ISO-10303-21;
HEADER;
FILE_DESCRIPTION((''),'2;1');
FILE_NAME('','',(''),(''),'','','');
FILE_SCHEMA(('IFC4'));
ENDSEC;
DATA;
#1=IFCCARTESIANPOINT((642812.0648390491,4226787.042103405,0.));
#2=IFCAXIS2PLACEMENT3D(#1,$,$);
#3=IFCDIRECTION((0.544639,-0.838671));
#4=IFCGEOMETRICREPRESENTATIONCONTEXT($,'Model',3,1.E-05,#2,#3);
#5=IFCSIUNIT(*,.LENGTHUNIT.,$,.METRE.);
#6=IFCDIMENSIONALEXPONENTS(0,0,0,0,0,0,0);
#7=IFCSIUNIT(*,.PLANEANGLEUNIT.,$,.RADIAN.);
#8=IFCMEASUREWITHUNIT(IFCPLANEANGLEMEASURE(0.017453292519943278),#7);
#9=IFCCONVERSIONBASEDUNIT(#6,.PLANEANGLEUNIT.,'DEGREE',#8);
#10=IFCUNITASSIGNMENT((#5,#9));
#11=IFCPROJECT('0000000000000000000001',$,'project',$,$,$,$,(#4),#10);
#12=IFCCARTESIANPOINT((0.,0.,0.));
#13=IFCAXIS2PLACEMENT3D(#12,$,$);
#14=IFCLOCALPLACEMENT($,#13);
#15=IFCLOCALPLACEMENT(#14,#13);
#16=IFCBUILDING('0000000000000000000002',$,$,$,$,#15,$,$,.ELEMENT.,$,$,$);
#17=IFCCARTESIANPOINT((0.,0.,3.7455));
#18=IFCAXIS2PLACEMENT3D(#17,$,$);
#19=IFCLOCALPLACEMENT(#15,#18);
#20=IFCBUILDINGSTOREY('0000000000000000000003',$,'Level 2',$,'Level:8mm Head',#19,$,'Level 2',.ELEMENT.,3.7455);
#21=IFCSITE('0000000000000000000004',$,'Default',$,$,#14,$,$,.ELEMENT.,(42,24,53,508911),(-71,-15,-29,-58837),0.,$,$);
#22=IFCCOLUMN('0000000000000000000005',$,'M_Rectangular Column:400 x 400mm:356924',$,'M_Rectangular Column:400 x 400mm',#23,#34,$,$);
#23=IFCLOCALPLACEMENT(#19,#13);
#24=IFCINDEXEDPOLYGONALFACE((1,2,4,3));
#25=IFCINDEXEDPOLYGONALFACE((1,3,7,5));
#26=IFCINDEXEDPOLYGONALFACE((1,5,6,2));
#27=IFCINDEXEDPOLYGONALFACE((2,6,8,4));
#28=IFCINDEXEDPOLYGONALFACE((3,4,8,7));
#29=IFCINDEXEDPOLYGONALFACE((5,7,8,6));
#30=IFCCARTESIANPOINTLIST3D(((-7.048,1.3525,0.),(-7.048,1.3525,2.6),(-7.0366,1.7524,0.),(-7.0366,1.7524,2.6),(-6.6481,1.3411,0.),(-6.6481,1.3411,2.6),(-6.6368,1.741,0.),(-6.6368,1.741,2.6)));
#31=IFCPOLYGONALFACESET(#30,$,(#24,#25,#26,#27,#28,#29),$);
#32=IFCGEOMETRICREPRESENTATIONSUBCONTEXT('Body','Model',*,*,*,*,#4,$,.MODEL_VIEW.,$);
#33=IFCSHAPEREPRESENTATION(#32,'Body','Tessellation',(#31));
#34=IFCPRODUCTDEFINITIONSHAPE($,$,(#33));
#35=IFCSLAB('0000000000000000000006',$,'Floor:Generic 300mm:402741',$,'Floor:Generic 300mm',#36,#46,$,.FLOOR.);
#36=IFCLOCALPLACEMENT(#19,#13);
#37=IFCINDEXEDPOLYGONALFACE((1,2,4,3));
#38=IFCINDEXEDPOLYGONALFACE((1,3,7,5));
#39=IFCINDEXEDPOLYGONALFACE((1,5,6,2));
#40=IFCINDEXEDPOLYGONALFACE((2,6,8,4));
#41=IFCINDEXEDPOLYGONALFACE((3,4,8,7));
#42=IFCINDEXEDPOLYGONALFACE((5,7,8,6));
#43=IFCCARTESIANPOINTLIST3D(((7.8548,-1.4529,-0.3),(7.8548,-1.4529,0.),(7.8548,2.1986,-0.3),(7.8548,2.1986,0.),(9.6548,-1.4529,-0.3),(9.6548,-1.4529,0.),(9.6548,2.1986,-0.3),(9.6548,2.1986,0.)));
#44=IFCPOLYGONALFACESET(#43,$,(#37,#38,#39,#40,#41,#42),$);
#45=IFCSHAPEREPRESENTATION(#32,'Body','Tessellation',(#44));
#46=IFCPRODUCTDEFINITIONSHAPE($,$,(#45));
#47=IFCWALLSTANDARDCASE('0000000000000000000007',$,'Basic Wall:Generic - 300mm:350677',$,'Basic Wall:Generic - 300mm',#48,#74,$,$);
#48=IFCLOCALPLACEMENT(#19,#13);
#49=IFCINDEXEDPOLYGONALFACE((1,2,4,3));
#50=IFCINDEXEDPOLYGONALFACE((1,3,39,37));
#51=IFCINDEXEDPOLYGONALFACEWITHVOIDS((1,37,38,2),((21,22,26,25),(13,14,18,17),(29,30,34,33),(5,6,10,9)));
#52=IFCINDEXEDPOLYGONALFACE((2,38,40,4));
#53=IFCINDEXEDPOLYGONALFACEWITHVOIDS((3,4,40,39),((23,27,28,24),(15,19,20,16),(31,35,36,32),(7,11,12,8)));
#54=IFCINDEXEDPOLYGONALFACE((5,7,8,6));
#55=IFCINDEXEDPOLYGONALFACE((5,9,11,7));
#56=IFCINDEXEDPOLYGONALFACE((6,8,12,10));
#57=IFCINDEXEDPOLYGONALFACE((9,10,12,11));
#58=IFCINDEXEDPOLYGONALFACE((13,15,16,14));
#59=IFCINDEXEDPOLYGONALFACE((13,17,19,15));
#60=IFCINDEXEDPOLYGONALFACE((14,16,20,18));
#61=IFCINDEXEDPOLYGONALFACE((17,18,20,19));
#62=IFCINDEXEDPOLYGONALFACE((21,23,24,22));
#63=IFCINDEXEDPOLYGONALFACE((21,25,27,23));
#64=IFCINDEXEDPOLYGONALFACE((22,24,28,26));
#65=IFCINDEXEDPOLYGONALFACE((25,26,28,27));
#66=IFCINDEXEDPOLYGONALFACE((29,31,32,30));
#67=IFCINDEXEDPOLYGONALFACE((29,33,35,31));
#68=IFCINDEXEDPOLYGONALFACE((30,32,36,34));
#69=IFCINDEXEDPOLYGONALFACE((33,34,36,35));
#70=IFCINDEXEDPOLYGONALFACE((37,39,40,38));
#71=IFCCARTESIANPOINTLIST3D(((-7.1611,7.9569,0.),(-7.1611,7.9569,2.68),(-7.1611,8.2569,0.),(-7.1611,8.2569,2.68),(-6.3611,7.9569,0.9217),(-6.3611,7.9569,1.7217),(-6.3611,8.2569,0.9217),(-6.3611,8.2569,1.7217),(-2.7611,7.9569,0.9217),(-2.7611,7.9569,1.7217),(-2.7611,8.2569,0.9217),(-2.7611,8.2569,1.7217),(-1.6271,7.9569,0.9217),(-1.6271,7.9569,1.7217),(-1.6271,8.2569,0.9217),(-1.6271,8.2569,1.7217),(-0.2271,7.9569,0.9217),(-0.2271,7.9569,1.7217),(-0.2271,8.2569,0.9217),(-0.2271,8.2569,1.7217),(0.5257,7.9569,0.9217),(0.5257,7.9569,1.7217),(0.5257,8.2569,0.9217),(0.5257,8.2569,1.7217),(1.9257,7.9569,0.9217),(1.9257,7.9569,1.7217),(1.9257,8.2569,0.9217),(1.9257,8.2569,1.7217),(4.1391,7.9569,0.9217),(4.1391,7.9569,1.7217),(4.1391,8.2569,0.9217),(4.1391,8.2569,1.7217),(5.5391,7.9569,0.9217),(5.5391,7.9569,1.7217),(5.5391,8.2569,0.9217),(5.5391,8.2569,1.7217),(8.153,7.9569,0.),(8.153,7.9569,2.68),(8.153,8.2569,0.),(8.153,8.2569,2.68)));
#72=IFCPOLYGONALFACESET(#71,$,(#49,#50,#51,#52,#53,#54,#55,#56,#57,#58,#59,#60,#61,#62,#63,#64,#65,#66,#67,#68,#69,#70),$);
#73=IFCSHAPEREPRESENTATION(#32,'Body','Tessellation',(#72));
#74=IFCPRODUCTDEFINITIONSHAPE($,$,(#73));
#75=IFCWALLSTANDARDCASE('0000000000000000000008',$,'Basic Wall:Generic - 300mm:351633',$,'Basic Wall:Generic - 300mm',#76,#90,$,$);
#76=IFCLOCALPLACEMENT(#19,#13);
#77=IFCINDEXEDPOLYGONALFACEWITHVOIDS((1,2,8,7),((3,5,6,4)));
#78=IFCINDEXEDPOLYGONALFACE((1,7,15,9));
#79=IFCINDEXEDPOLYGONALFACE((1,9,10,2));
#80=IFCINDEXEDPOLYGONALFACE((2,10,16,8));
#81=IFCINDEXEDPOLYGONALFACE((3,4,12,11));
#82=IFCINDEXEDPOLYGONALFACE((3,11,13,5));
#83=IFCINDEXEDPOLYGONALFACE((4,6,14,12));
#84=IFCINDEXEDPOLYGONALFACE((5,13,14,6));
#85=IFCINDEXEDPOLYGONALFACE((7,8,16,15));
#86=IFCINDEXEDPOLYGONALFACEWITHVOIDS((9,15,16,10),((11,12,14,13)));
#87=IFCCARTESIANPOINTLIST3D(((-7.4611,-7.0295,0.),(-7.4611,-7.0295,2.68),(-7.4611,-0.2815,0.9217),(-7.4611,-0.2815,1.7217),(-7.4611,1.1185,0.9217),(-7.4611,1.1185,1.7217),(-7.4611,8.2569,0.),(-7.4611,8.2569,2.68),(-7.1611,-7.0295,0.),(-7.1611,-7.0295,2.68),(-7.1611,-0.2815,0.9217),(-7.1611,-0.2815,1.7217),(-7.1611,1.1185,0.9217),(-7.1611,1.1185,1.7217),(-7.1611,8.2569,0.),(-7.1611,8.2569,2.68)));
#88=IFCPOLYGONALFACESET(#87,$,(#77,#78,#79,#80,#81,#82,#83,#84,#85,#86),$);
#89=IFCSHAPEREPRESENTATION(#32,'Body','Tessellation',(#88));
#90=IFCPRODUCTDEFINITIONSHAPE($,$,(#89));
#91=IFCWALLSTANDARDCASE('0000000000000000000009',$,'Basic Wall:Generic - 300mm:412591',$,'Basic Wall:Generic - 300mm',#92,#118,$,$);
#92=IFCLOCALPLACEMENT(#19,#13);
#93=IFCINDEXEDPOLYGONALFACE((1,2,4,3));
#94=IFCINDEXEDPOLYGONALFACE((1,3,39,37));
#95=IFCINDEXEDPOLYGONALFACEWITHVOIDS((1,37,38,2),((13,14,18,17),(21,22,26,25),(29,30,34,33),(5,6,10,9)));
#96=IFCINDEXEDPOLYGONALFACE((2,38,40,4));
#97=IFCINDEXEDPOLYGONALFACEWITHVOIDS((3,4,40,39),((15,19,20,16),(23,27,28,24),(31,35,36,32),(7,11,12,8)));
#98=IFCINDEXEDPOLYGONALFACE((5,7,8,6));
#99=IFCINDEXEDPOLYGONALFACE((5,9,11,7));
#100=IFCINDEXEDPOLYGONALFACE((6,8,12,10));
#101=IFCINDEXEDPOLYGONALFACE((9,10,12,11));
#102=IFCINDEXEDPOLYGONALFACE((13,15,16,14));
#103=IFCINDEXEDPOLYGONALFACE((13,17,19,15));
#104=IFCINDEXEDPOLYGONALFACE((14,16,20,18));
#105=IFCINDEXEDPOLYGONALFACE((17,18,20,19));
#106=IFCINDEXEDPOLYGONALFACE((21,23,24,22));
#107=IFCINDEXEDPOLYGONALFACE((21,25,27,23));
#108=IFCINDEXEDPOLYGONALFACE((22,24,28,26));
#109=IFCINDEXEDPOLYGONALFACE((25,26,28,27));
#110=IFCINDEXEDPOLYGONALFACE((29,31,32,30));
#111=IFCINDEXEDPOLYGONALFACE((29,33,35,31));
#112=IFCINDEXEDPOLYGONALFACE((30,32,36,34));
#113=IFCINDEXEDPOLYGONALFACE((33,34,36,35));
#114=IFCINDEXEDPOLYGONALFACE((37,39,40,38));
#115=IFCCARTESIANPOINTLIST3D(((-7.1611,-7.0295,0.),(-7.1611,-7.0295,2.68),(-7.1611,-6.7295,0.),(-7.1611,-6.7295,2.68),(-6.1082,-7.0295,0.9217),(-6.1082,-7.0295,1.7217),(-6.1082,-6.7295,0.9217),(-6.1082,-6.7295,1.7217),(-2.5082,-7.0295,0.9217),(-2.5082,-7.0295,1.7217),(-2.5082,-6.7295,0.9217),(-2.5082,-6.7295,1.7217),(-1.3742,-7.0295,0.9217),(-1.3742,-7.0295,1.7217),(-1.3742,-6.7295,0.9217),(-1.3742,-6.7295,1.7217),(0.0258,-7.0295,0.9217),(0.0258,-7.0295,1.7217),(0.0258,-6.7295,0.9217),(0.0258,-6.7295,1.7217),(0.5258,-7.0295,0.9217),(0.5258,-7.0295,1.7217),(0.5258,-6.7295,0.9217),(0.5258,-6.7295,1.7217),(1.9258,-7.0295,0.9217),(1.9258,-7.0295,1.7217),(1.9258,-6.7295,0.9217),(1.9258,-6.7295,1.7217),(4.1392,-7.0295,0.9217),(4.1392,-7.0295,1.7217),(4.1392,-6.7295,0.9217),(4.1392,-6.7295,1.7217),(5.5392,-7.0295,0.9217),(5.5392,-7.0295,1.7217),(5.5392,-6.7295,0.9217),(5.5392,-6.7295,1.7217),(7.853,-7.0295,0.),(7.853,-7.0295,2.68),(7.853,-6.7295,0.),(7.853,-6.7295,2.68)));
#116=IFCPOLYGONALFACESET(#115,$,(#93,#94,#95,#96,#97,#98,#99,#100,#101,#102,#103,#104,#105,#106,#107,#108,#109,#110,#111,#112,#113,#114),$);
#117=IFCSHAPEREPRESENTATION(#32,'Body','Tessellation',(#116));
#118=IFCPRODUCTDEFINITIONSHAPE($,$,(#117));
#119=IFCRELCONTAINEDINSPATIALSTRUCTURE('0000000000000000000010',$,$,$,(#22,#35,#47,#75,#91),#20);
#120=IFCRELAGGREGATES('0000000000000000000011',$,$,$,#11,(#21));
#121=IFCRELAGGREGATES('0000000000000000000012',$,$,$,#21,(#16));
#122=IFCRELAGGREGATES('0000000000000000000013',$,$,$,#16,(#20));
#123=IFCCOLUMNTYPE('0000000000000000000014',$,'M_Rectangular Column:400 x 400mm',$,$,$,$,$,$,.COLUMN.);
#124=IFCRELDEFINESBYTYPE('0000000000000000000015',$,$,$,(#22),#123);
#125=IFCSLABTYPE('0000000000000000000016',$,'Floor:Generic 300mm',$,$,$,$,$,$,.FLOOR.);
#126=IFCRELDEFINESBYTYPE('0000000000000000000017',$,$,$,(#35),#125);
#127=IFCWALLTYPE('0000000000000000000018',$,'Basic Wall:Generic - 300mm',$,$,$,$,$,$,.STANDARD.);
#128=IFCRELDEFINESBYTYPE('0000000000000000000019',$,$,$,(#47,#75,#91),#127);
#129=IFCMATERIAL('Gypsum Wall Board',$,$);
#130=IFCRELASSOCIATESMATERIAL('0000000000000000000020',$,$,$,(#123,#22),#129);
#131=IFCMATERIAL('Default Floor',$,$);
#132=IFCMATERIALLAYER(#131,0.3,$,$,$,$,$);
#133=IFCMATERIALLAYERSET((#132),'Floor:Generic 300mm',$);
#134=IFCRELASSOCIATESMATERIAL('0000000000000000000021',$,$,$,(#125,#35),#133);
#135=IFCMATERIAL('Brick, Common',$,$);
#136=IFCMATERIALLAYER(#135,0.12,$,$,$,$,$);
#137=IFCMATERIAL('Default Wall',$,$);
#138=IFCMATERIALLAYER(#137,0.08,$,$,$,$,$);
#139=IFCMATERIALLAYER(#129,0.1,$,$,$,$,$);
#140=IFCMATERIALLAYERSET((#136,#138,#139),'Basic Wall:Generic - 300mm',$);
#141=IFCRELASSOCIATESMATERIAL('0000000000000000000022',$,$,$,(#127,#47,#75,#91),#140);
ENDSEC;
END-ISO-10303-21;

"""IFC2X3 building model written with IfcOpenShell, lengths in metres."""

from ifc_helpers import new_model, entity, si_unit, converted_unit, direction, frame, frame_2d, origin, place, context, subcontext, project, spatial, rectangle, extrude, clip, halfspace, source, transform, mapped, material, layer, layer_set, layer_usage, type_object, type_shapes, element, save


model = new_model("IFC2X3")

# Units and contexts
model_context = context("Model", 3, precision=1e-05, world=frame((642812.0648390491, 4226787.042103405, 0.0)), true_north=direction((0.544639, -0.838671)))
body_context = subcontext(model_context, "Body", "Model", "MODEL_VIEW")
ifc_project = project(units=[si_unit("LENGTHUNIT", "METRE"), converted_unit("PLANEANGLEUNIT", "DEGREE", entity("IfcPlaneAngleMeasure", 0.017453292519943278), si_unit("PLANEANGLEUNIT", "RADIAN"), dimensions=[0, 0, 0, 0, 0, 0, 0])], contexts=[model_context])

# Site, building, storey
site_placement = place(None, origin())
site = spatial("IfcSite", under=ifc_project, at=site_placement, Name="Default", CompositionType="ELEMENT", RefLatitude=(42, 24, 53, 508911), RefLongitude=(-71, -15, -29, -58837), RefElevation=0.0)
building_placement = place(site_placement, origin())
building = spatial("IfcBuilding", under=site, at=building_placement, CompositionType="ELEMENT")
storey_placement = place(building_placement, frame((0.0, 0.0, 3.7455)))
storey = spatial("IfcBuildingStorey", under=building, at=storey_placement, Name="Level 2", ObjectType="Level:8mm Head", LongName="Level 2", CompositionType="ELEMENT", Elevation=3.7455)

# Column
ifc_material_1 = material(Name="Gypsum Wall Board")
column_type_1 = type_object("IfcColumnType", Name="M_Rectangular Column:400 x 400mm", PredefinedType="COLUMN", material=ifc_material_1)
shared_shape_1 = source(origin(), body_context, "Body", "SweptSolid", [
    extrude(rectangle(XDim=0.4, YDim=0.4, at=frame_2d((0.0, 0.0), x_axis=(1.0, 0.0))), frame((-6.8424, 1.5467, 3.7455), z_axis=(0.0, 0.0, 1.0), x_axis=(0.999595, -0.02845, 0.0)), (0.0, 0.0, 1.0), 2.6),
])
type_shapes(column_type_1, [shared_shape_1])
column_1_placement = place(storey_placement, frame((0.0, 0.0, -3.7455)))
element("IfcColumn", 1, at=column_1_placement, inside=storey, type_object=column_type_1, material=ifc_material_1, Name="M_Rectangular Column:400 x 400mm:356924", ObjectType="M_Rectangular Column:400 x 400mm", context=body_context, shape_type="MappedRepresentation", body=[
    mapped(shared_shape_1, transform((0.0, 0.0, 0.0), scale=1.0)),
])

# Slab
ifc_material_2 = material(Name="Default Floor")
ifc_layer_1 = layer(ifc_material_2, 0.3)
ifc_layer_set_1 = layer_set([ifc_layer_1], Name="Floor:Generic 300mm")
ifc_layer_usage_1 = layer_usage(ifc_layer_set_1, "AXIS3", "POSITIVE", 0.0)
slab_type_1 = type_object("IfcSlabType", Name="Floor:Generic 300mm", PredefinedType="FLOOR", material=ifc_layer_set_1)
slab_1_placement = place(storey_placement, origin())
element("IfcSlab", 2, at=slab_1_placement, inside=storey, type_object=slab_type_1, material=ifc_layer_usage_1, Name="Floor:Generic 300mm:402741", ObjectType="Floor:Generic 300mm", PredefinedType="FLOOR", context=body_context, shape_type="SweptSolid", body=[
    extrude(rectangle(XDim=3.6515, YDim=1.8, at=frame_2d((0.0, 0.0), x_axis=(1.0, 0.0))), frame((8.7548, 0.3729, 0.0), z_axis=(0.0, 0.0, -1.0), x_axis=(0.0, 1.0, 0.0)), (0.0, 0.0, 1.0), 0.3),
])

# Wall, openings
ifc_material_3 = material(Name="Brick, Common")
ifc_layer_2 = layer(ifc_material_3, 0.12)
ifc_material_4 = material(Name="Default Wall")
ifc_layer_3 = layer(ifc_material_4, 0.08)
ifc_layer_4 = layer(ifc_material_1, 0.1)
ifc_layer_set_2 = layer_set([ifc_layer_2, ifc_layer_3, ifc_layer_4], Name="Basic Wall:Generic - 300mm")
ifc_layer_usage_2 = layer_usage(ifc_layer_set_2, "AXIS2", "POSITIVE", -0.15)
wall_type = type_object("IfcWallType", Name="Basic Wall:Generic - 300mm", PredefinedType="STANDARD", material=ifc_layer_set_2)
wall_1_placement = place(storey_placement, frame((8.153, 8.1069, 0.0), z_axis=(0.0, 0.0, 1.0), x_axis=(-1.0, 0.0, 0.0)))
wall_1 = element("IfcWallStandardCase", 3, at=wall_1_placement, inside=storey, type_object=wall_type, material=ifc_layer_usage_2, Name="Basic Wall:Generic - 300mm:350677", ObjectType="Basic Wall:Generic - 300mm", context=body_context, shape_type="Clipping", body=[
    clip(extrude(rectangle(XDim=15.314, YDim=0.3, at=frame_2d((7.657, 0.0), x_axis=(-1.0, 0.0))), origin(), (0.0, 0.0, 1.0), 2.68), halfspace(frame((0.0, 0.0, -3.7455)), True)),
])
opening_1_placement = place(wall_1_placement, frame((14.514, 0.15, 0.9217)))
element("IfcOpeningElement", 4, at=opening_1_placement, cuts=wall_1, ObjectType="Opening", context=body_context, shape_type="SweptSolid", body=[
    extrude(rectangle(XDim=0.8, YDim=3.6, at=frame_2d((0.4, 1.8), x_axis=(-1.0, 0.0))), frame((0.0, 0.0, 0.0), z_axis=(0.0, -1.0, 0.0), x_axis=(0.0, 0.0, 1.0)), (0.0, 0.0, 1.0), 0.3),
])
opening_2_placement = place(wall_1_placement, frame((9.7801, 0.15, 0.9217)))
element("IfcOpeningElement", 5, at=opening_2_placement, cuts=wall_1, ObjectType="Opening", context=body_context, shape_type="SweptSolid", body=[
    extrude(rectangle(XDim=0.8, YDim=1.4, at=frame_2d((0.4, 0.7), x_axis=(-1.0, 0.0))), frame((0.0, 0.0, 0.0), z_axis=(0.0, -1.0, 0.0), x_axis=(0.0, 0.0, 1.0)), (0.0, 0.0, 1.0), 0.3),
])
opening_3_placement = place(wall_1_placement, frame((7.6272, 0.15, 0.9217)))
element("IfcOpeningElement", 6, at=opening_3_placement, cuts=wall_1, ObjectType="Opening", context=body_context, shape_type="SweptSolid", body=[
    extrude(rectangle(XDim=0.8, YDim=1.4, at=frame_2d((0.4, 0.7), x_axis=(-1.0, 0.0))), frame((0.0, 0.0, 0.0), z_axis=(0.0, -1.0, 0.0), x_axis=(0.0, 0.0, 1.0)), (0.0, 0.0, 1.0), 0.3),
])
opening_4_placement = place(wall_1_placement, frame((4.0138, 0.15, 0.9217)))
element("IfcOpeningElement", 7, at=opening_4_placement, cuts=wall_1, ObjectType="Opening", context=body_context, shape_type="SweptSolid", body=[
    extrude(rectangle(XDim=0.8, YDim=1.4, at=frame_2d((0.4, 0.7), x_axis=(-1.0, 0.0))), frame((0.0, 0.0, 0.0), z_axis=(0.0, -1.0, 0.0), x_axis=(0.0, 0.0, 1.0)), (0.0, 0.0, 1.0), 0.3),
])

# Wall, opening
wall_2_placement = place(storey_placement, frame((-7.3111, 8.2569, 0.0), z_axis=(0.0, 0.0, 1.0), x_axis=(0.0, -1.0, 0.0)))
wall_2 = element("IfcWallStandardCase", 8, at=wall_2_placement, inside=storey, type_object=wall_type, material=ifc_layer_usage_2, Name="Basic Wall:Generic - 300mm:351633", ObjectType="Basic Wall:Generic - 300mm", context=body_context, shape_type="Clipping", body=[
    clip(extrude(rectangle(XDim=15.2864, YDim=0.3, at=frame_2d((7.6432, 0.0), x_axis=(-1.0, 0.0))), origin(), (0.0, 0.0, 1.0), 2.68), halfspace(frame((0.0, 0.0, -3.7455)), True)),
])
opening_5_placement = place(wall_2_placement, frame((8.5384, 0.15, 0.9217)))
element("IfcOpeningElement", 9, at=opening_5_placement, cuts=wall_2, ObjectType="Opening", context=body_context, shape_type="SweptSolid", body=[
    extrude(rectangle(XDim=0.8, YDim=1.4, at=frame_2d((0.4, 0.7), x_axis=(-1.0, 0.0))), frame((0.0, 0.0, 0.0), z_axis=(0.0, -1.0, 0.0), x_axis=(0.0, 0.0, 1.0)), (0.0, 0.0, 1.0), 0.3),
])

# Wall, openings
wall_3_placement = place(storey_placement, frame((-7.1611, -6.8795, 0.0)))
wall_3 = element("IfcWallStandardCase", 10, at=wall_3_placement, inside=storey, type_object=wall_type, material=ifc_layer_usage_2, Name="Basic Wall:Generic - 300mm:412591", ObjectType="Basic Wall:Generic - 300mm", context=body_context, shape_type="Clipping", body=[
    clip(extrude(rectangle(XDim=15.014, YDim=0.3, at=frame_2d((7.507, 0.0), x_axis=(-1.0, 0.0))), origin(), (0.0, 0.0, 1.0), 2.68), halfspace(frame((0.0, 0.0, -3.7455)), True)),
])
opening_6_placement = place(wall_3_placement, frame((4.6528, 0.15, 0.9217)))
element("IfcOpeningElement", 11, at=opening_6_placement, cuts=wall_3, ObjectType="Opening", context=body_context, shape_type="SweptSolid", body=[
    extrude(rectangle(XDim=0.8, YDim=3.6, at=frame_2d((0.4, 1.8), x_axis=(-1.0, 0.0))), frame((0.0, 0.0, 0.0), z_axis=(0.0, -1.0, 0.0), x_axis=(0.0, 0.0, 1.0)), (0.0, 0.0, 1.0), 0.3),
])
opening_7_placement = place(wall_3_placement, frame((7.1868, 0.15, 0.9217)))
element("IfcOpeningElement", 12, at=opening_7_placement, cuts=wall_3, ObjectType="Opening", context=body_context, shape_type="SweptSolid", body=[
    extrude(rectangle(XDim=0.8, YDim=1.4, at=frame_2d((0.4, 0.7), x_axis=(-1.0, 0.0))), frame((0.0, 0.0, 0.0), z_axis=(0.0, -1.0, 0.0), x_axis=(0.0, 0.0, 1.0)), (0.0, 0.0, 1.0), 0.3),
])
opening_8_placement = place(wall_3_placement, frame((9.0868, 0.15, 0.9217)))
element("IfcOpeningElement", 13, at=opening_8_placement, cuts=wall_3, ObjectType="Opening", context=body_context, shape_type="SweptSolid", body=[
    extrude(rectangle(XDim=0.8, YDim=1.4, at=frame_2d((0.4, 0.7), x_axis=(-1.0, 0.0))), frame((0.0, 0.0, 0.0), z_axis=(0.0, -1.0, 0.0), x_axis=(0.0, 0.0, 1.0)), (0.0, 0.0, 1.0), 0.3),
])
opening_9_placement = place(wall_3_placement, frame((12.7002, 0.15, 0.9217)))
element("IfcOpeningElement", 14, at=opening_9_placement, cuts=wall_3, ObjectType="Opening", context=body_context, shape_type="SweptSolid", body=[
    extrude(rectangle(XDim=0.8, YDim=1.4, at=frame_2d((0.4, 0.7), x_axis=(-1.0, 0.0))), frame((0.0, 0.0, 0.0), z_axis=(0.0, -1.0, 0.0), x_axis=(0.0, 0.0, 1.0)), (0.0, 0.0, 1.0), 0.3),
])

save(model, "model.ifc")
